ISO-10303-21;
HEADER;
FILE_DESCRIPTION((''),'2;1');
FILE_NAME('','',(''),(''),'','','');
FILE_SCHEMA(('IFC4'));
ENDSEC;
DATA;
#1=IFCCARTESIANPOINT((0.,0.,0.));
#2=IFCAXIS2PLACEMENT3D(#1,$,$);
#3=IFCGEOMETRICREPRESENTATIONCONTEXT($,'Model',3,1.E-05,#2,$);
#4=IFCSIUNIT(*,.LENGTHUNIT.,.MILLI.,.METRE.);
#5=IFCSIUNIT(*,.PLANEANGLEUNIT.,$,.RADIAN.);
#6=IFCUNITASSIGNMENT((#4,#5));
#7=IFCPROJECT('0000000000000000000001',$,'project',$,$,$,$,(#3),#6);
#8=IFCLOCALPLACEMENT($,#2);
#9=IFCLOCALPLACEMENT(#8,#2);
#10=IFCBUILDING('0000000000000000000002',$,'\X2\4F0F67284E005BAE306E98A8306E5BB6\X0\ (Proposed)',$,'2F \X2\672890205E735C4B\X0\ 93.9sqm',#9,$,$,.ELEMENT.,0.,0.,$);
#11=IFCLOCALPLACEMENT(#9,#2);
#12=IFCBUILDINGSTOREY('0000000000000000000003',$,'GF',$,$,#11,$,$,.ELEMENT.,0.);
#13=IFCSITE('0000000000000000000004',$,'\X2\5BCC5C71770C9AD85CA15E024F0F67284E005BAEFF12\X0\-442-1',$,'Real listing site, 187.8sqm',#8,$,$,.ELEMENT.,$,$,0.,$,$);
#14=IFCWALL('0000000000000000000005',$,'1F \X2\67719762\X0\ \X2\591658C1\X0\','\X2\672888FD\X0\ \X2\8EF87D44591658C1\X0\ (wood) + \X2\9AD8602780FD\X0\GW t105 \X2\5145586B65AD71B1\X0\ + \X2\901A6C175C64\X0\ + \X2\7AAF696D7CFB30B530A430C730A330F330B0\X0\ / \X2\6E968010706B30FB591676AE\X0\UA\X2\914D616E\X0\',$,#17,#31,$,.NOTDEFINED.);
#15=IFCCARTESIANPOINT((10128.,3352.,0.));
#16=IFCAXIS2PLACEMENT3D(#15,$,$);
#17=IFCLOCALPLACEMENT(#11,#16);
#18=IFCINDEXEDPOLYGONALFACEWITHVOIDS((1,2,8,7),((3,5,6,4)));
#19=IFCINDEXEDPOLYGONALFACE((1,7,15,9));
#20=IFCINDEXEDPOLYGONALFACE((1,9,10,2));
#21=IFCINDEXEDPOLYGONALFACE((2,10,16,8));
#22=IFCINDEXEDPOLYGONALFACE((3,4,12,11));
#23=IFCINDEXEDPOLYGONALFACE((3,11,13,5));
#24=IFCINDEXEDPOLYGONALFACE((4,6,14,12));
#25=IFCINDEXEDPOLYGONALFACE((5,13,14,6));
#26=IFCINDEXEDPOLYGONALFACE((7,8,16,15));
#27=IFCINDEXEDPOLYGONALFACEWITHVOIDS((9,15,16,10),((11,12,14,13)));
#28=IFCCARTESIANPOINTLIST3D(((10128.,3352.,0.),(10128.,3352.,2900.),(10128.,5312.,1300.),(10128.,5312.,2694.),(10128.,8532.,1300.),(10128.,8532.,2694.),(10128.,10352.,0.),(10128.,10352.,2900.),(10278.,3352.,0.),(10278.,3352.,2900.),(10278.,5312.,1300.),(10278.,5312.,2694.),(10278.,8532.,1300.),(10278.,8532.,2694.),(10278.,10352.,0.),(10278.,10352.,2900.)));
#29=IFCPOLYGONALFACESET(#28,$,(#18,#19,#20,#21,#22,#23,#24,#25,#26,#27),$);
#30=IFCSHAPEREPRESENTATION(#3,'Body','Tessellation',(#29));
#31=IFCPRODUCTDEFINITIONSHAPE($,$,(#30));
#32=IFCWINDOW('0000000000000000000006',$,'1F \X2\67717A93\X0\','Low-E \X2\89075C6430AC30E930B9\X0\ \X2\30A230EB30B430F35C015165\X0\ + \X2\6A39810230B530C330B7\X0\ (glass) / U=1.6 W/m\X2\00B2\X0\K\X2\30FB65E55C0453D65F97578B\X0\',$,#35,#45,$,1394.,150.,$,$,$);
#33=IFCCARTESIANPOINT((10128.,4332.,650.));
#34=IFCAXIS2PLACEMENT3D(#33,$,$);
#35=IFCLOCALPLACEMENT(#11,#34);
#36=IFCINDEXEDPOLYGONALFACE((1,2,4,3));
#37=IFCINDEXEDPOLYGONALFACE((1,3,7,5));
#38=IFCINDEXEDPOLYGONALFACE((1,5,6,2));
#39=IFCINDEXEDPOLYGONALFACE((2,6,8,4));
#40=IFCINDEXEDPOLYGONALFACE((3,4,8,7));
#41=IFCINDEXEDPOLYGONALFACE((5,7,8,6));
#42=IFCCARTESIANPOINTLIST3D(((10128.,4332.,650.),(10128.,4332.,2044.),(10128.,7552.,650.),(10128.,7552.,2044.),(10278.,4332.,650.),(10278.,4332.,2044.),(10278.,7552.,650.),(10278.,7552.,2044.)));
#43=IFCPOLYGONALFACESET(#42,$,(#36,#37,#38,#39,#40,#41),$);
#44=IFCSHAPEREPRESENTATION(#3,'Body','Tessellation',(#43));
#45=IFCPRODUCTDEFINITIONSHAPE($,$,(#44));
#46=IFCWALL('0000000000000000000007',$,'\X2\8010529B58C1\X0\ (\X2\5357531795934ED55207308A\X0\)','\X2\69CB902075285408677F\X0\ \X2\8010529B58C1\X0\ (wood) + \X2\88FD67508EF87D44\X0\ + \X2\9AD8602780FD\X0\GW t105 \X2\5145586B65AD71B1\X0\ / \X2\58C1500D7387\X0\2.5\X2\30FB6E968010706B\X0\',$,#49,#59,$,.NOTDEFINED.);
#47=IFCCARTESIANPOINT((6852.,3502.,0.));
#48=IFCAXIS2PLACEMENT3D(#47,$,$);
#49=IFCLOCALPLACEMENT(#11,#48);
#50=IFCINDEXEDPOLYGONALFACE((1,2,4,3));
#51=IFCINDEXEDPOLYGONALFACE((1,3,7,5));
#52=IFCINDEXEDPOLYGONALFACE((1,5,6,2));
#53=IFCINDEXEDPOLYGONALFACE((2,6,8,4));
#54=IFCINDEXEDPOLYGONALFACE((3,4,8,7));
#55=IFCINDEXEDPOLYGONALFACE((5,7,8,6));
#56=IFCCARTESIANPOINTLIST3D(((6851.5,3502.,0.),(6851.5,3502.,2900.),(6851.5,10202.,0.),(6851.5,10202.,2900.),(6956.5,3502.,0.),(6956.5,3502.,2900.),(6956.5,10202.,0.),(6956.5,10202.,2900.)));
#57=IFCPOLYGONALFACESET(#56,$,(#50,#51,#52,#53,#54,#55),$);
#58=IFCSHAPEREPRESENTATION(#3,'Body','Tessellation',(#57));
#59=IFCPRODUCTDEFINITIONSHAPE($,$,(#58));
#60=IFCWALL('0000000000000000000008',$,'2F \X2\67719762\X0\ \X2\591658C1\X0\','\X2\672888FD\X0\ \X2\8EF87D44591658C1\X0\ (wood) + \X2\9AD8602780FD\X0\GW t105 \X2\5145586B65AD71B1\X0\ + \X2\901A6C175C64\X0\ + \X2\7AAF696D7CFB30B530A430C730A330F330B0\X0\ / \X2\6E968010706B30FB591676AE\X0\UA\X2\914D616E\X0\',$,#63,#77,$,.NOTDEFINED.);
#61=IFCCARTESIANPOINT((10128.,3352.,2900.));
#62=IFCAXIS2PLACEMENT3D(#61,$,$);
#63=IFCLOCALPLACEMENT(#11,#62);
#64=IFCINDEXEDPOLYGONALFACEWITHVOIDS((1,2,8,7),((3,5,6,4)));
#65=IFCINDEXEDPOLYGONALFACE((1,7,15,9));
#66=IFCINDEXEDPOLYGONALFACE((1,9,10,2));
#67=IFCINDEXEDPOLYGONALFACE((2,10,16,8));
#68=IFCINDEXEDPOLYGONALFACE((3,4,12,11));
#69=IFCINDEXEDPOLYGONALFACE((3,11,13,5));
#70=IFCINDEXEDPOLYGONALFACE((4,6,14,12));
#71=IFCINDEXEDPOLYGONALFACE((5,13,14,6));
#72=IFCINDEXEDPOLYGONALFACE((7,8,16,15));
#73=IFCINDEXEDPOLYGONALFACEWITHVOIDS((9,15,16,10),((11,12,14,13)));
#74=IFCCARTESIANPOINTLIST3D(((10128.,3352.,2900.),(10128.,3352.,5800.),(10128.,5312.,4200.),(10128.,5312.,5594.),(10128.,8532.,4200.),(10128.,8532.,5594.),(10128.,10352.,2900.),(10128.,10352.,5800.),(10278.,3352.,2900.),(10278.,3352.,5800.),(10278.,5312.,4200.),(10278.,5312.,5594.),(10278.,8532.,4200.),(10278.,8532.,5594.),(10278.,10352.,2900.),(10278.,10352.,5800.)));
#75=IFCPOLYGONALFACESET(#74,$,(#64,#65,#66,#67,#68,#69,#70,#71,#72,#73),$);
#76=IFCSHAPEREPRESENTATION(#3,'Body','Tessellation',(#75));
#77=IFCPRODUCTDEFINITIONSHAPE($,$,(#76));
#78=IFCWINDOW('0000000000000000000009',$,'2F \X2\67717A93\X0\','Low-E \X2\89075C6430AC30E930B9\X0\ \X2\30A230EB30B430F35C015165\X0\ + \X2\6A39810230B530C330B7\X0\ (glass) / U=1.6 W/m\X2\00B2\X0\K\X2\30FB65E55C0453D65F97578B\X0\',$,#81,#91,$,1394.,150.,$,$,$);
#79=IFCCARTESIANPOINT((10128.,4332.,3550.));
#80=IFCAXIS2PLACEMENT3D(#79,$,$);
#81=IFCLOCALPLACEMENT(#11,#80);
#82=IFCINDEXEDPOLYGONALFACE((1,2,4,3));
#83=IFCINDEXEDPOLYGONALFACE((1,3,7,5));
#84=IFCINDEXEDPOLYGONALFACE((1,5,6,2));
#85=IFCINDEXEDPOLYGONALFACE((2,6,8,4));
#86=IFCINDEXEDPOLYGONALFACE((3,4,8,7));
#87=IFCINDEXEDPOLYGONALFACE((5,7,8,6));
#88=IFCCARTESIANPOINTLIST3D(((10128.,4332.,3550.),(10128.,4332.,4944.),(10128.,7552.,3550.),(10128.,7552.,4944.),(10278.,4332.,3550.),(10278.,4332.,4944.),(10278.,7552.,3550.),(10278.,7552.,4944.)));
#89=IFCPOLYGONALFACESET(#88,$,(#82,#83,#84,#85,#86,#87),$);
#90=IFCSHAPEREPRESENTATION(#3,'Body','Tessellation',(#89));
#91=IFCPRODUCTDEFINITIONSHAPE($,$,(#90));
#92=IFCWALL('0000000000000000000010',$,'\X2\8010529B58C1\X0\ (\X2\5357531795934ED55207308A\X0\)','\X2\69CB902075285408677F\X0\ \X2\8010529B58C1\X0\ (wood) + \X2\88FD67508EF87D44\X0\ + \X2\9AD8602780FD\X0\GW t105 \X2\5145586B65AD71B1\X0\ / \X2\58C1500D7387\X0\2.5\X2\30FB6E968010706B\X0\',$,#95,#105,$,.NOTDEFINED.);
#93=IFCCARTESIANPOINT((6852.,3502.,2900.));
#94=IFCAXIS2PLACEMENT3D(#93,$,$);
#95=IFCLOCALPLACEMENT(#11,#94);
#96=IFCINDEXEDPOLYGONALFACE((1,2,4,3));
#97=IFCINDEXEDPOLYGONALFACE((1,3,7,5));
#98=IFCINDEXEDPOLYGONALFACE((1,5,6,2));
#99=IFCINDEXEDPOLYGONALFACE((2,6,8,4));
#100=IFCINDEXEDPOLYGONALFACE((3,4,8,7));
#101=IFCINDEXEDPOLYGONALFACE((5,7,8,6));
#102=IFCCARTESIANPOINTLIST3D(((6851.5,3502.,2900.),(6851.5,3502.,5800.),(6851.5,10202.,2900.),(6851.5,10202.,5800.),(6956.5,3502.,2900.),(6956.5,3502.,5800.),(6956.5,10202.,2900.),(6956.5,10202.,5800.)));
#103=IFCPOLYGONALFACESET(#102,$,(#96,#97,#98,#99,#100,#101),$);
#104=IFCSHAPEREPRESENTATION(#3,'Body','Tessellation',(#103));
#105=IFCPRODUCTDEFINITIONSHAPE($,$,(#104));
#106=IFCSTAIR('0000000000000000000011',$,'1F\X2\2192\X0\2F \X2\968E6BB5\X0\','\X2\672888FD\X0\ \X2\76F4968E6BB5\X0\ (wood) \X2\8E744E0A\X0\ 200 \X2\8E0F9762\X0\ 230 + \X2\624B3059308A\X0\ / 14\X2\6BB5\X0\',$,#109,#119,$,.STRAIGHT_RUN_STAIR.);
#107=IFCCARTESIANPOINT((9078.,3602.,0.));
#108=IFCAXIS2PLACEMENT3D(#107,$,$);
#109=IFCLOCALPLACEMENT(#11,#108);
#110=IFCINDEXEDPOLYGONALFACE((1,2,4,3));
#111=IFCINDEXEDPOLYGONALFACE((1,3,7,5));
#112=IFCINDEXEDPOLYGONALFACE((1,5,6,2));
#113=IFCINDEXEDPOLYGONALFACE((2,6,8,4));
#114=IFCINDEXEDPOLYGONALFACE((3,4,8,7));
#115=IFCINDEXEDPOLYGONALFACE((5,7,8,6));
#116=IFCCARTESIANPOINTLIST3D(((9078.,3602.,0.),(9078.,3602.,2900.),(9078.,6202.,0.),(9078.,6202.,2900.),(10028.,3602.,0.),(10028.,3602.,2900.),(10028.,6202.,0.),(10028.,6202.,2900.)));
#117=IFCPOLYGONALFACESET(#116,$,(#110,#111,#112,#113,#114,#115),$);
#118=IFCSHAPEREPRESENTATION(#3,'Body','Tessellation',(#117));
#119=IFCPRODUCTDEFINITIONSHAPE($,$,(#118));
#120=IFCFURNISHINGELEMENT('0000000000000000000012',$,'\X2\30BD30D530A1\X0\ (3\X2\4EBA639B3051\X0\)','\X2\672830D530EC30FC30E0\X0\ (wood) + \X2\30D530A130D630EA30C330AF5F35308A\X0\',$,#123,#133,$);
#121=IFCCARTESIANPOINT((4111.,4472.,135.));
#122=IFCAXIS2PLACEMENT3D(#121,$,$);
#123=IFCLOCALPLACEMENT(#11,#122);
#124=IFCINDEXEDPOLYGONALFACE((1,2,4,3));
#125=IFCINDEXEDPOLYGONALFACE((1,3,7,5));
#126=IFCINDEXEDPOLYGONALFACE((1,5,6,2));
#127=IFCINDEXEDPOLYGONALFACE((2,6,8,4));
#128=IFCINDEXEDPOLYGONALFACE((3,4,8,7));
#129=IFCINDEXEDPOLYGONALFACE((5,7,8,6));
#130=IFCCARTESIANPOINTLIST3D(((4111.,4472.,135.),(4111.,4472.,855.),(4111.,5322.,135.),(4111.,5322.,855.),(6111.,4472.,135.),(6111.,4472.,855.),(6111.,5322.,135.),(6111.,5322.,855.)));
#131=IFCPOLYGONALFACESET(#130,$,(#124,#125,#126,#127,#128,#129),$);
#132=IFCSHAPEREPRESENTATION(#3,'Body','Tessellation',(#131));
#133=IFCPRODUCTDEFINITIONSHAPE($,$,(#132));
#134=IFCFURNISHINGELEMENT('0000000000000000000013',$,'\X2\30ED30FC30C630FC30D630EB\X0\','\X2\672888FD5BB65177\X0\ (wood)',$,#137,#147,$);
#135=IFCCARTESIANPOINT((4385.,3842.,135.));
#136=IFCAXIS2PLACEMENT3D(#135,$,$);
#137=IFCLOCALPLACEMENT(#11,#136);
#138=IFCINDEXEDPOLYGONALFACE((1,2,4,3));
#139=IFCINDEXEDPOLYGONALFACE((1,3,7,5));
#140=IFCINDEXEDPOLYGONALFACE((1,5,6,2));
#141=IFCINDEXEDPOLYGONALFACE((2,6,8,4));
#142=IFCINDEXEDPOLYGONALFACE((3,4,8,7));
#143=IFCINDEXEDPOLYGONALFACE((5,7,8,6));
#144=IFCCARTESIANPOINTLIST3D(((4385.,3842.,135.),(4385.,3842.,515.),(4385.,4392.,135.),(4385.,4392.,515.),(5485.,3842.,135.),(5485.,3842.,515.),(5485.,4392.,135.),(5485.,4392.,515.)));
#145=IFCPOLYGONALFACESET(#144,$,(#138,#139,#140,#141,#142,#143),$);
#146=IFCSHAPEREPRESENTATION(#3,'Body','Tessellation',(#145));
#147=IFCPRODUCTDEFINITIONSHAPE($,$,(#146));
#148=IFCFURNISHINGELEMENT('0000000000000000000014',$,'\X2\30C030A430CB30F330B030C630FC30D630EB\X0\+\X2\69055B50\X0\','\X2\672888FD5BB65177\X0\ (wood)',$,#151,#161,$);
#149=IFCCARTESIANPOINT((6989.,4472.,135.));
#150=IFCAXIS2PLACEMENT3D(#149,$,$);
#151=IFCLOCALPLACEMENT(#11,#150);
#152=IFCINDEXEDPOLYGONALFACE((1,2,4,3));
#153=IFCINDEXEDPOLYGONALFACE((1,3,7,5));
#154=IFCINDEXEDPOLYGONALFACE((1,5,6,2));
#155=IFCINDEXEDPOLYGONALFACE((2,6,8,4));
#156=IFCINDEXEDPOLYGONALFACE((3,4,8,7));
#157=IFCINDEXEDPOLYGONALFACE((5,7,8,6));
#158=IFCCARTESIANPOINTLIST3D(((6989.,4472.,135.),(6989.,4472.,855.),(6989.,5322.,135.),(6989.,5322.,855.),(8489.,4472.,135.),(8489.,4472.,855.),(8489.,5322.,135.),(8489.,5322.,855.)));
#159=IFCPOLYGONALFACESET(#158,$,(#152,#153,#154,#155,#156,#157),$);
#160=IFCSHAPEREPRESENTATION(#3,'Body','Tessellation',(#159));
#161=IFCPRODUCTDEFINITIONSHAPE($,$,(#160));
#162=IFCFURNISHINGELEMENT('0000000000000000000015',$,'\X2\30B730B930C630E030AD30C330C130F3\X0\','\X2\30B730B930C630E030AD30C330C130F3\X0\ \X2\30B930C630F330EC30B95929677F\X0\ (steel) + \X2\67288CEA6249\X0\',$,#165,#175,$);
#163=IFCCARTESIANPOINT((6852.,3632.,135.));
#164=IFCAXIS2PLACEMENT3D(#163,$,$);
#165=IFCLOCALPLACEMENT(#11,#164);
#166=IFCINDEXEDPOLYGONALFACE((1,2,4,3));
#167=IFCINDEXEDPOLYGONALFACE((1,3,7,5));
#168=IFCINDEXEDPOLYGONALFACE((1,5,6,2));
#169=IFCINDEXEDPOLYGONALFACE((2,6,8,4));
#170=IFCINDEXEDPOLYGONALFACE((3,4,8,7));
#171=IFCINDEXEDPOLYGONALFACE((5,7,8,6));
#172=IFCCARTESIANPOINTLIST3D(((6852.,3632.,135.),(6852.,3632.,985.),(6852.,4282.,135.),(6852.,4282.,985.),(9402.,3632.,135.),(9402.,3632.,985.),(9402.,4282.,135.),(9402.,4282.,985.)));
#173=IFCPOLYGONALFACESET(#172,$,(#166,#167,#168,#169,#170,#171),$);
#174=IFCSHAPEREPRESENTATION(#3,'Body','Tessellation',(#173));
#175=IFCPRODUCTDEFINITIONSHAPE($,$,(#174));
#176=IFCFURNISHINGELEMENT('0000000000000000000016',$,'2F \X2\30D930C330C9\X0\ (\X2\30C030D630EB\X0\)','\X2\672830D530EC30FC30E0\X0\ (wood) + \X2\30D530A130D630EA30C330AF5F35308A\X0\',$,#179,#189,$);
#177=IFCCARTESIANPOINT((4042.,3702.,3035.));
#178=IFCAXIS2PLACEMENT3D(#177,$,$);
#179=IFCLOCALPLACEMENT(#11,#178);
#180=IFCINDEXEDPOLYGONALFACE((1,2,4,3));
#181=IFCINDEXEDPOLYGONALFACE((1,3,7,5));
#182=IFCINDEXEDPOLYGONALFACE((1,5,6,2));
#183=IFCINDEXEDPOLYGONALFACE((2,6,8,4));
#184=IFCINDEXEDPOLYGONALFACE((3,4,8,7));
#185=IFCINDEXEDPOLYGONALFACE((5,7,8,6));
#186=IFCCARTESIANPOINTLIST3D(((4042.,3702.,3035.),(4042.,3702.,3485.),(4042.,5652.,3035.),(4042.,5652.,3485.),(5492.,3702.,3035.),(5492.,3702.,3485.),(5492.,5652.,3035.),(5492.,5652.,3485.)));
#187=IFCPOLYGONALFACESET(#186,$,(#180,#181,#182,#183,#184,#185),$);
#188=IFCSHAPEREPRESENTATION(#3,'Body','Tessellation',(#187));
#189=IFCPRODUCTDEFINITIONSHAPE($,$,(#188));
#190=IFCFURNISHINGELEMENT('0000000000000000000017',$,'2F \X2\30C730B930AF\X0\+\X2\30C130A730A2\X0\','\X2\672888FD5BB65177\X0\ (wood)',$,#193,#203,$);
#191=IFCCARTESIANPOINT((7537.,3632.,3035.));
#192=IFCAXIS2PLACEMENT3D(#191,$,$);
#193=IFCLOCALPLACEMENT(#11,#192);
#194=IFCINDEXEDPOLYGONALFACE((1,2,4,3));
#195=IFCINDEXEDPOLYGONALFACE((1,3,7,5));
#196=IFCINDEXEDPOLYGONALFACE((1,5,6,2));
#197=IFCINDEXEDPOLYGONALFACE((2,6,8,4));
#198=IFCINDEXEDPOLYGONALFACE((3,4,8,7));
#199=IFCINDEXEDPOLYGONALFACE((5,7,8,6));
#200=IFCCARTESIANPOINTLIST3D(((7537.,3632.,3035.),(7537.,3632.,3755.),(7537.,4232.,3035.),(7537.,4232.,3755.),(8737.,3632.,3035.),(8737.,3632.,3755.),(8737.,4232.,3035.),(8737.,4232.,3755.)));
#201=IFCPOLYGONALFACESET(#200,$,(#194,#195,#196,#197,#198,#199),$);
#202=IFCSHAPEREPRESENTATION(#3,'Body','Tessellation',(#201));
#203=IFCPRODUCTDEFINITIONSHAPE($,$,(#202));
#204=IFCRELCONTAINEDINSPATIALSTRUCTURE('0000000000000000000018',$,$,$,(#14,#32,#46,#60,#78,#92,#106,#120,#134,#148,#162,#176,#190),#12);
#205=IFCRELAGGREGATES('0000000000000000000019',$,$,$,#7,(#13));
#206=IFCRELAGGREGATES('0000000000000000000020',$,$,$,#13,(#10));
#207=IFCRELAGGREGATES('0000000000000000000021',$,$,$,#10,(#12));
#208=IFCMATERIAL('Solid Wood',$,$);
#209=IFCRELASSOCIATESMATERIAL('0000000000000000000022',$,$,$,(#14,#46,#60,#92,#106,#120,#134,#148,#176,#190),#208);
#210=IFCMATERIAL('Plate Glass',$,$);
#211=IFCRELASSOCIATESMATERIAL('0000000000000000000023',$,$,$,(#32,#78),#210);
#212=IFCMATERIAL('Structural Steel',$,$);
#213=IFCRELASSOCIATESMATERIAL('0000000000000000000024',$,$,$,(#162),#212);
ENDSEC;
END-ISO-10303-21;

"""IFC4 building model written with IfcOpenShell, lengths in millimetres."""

from ifc_helpers import new_model, si_unit, frame, frame_2d, origin, place, context, project, spatial, rectangle, extrude, material, element, fill, save


model = new_model("IFC4")

# Units and contexts
model_context = context("Model", 3, precision=1e-05, world=origin())
ifc_project = project(units=[si_unit("LENGTHUNIT", "METRE", prefix="MILLI"), si_unit("PLANEANGLEUNIT", "RADIAN")], contexts=[model_context])

# Site, building, storey
site_placement = place(None, origin())
site = spatial("IfcSite", under=ifc_project, at=site_placement, Name="富山県高岡市伏木一宮２-442-1", ObjectType="Real listing site, 187.8sqm", CompositionType="ELEMENT", RefElevation=0.0)
building_placement = place(site_placement, origin())
building = spatial("IfcBuilding", under=site, at=building_placement, Name="伏木一宮の風の家 (Proposed)", ObjectType="2F 木造平屋 93.9sqm", CompositionType="ELEMENT", ElevationOfRefHeight=0.0, ElevationOfTerrain=0.0)
storey_placement = place(building_placement, origin())
storey = spatial("IfcBuildingStorey", under=building, at=storey_placement, Name="GF", CompositionType="ELEMENT", Elevation=0.0)

# Wall, opening, window
ifc_material_1 = material(Name="Solid Wood")
wall_1_placement = place(storey_placement, frame((10128.0, 3352.0, 0.0)))
wall_1 = element("IfcWall", 1, at=wall_1_placement, inside=storey, material=ifc_material_1, Name="1F 東面 外壁", Description="木製 軸組外壁 (wood) + 高性能GW t105 充填断熱 + 通気層 + 窯業系サイディング / 準耐火・外皮UA配慮", PredefinedType="NOTDEFINED", context=model_context, shape_type="SweptSolid", body=[
    extrude(rectangle(XDim=150.0, YDim=7000.0, at=frame_2d((75.0, 3500.0))), frame((10128.0, 3352.0, 0.0)), (0.0, 0.0, 1.0), 2900.0),
])
opening_1_placement = place(storey_placement, frame((10128.0, 4332.0, 650.0)))
opening_1 = element("IfcOpeningElement", 2, at=opening_1_placement, cuts=wall_1, PredefinedType="NOTDEFINED", context=model_context, shape_type="SweptSolid", body=[
    extrude(rectangle(XDim=150.0, YDim=3220.0, at=frame_2d((75.0, 1610.0))), frame((10128.0, 4332.0, 650.0)), (0.0, 0.0, 1.0), 1394.0),
])
ifc_material_2 = material(Name="Plate Glass")
window_1_placement = place(storey_placement, frame((10128.0, 4332.0, 650.0)))
window_1 = element("IfcWindow", 3, at=window_1_placement, inside=storey, material=ifc_material_2, Name="1F 東窓", Description="Low-E 複層ガラス アルゴン封入 + 樹脂サッシ (glass) / U=1.6 W/m²K・日射取得型", OverallHeight=1394.0, OverallWidth=150.0, context=model_context, shape_type="SweptSolid", body=[
    extrude(rectangle(XDim=150.0, YDim=3220.0, at=frame_2d((75.0, 1610.0))), frame((10128.0, 4332.0, 650.0)), (0.0, 0.0, 1.0), 1394.0),
])
fill(opening_1, window_1)

# Wall
wall_2_placement = place(storey_placement, frame((6852.0, 3502.0, 0.0)))
element("IfcWall", 4, at=wall_2_placement, inside=storey, material=ifc_material_1, Name="耐力壁 (南北間仕切り)", Description="構造用合板 耐力壁 (wood) + 製材軸組 + 高性能GW t105 充填断熱 / 壁倍率2.5・準耐火", PredefinedType="NOTDEFINED", context=model_context, shape_type="SweptSolid", body=[
    extrude(rectangle(XDim=105.0, YDim=6700.0, at=frame_2d((52.0, 3350.0))), frame((6852.0, 3502.0, 0.0)), (0.0, 0.0, 1.0), 2900.0),
])

# Wall, opening, window
wall_3_placement = place(storey_placement, frame((10128.0, 3352.0, 2900.0)))
wall_3 = element("IfcWall", 5, at=wall_3_placement, inside=storey, material=ifc_material_1, Name="2F 東面 外壁", Description="木製 軸組外壁 (wood) + 高性能GW t105 充填断熱 + 通気層 + 窯業系サイディング / 準耐火・外皮UA配慮", PredefinedType="NOTDEFINED", context=model_context, shape_type="SweptSolid", body=[
    extrude(rectangle(XDim=150.0, YDim=7000.0, at=frame_2d((75.0, 3500.0))), frame((10128.0, 3352.0, 2900.0)), (0.0, 0.0, 1.0), 2900.0),
])
opening_2_placement = place(storey_placement, frame((10128.0, 4332.0, 3550.0)))
opening_2 = element("IfcOpeningElement", 6, at=opening_2_placement, cuts=wall_3, PredefinedType="NOTDEFINED", context=model_context, shape_type="SweptSolid", body=[
    extrude(rectangle(XDim=150.0, YDim=3220.0, at=frame_2d((75.0, 1610.0))), frame((10128.0, 4332.0, 3550.0)), (0.0, 0.0, 1.0), 1394.0),
])
window_2_placement = place(storey_placement, frame((10128.0, 4332.0, 3550.0)))
window_2 = element("IfcWindow", 7, at=window_2_placement, inside=storey, material=ifc_material_2, Name="2F 東窓", Description="Low-E 複層ガラス アルゴン封入 + 樹脂サッシ (glass) / U=1.6 W/m²K・日射取得型", OverallHeight=1394.0, OverallWidth=150.0, context=model_context, shape_type="SweptSolid", body=[
    extrude(rectangle(XDim=150.0, YDim=3220.0, at=frame_2d((75.0, 1610.0))), frame((10128.0, 4332.0, 3550.0)), (0.0, 0.0, 1.0), 1394.0),
])
fill(opening_2, window_2)

# Wall
wall_4_placement = place(storey_placement, frame((6852.0, 3502.0, 2900.0)))
element("IfcWall", 8, at=wall_4_placement, inside=storey, material=ifc_material_1, Name="耐力壁 (南北間仕切り)", Description="構造用合板 耐力壁 (wood) + 製材軸組 + 高性能GW t105 充填断熱 / 壁倍率2.5・準耐火", PredefinedType="NOTDEFINED", context=model_context, shape_type="SweptSolid", body=[
    extrude(rectangle(XDim=105.0, YDim=6700.0, at=frame_2d((52.0, 3350.0))), frame((6852.0, 3502.0, 2900.0)), (0.0, 0.0, 1.0), 2900.0),
])

# Stair
stair_placement = place(storey_placement, frame((9078.0, 3602.0, 0.0)))
element("IfcStair", 9, at=stair_placement, inside=storey, material=ifc_material_1, Name="1F→2F 階段", Description="木製 直階段 (wood) 蹴上 200 踏面 230 + 手すり / 14段", PredefinedType="STRAIGHT_RUN_STAIR", context=model_context, shape_type="SweptSolid", body=[
    extrude(rectangle(XDim=950.0, YDim=2600.0, at=frame_2d((475.0, 1300.0))), frame((9078.0, 3602.0, 0.0)), (0.0, 0.0, 1.0), 2900.0),
])

# Furnishing elements
furnishing_1_placement = place(storey_placement, frame((4111.0, 4472.0, 135.0)))
element("IfcFurnishingElement", 10, at=furnishing_1_placement, inside=storey, material=ifc_material_1, Name="ソファ (3人掛け)", Description="木フレーム (wood) + ファブリック張り", context=model_context, shape_type="SweptSolid", body=[
    extrude(rectangle(XDim=2000.0, YDim=850.0, at=frame_2d((1000.0, 425.0))), frame((4111.0, 4472.0, 135.0)), (0.0, 0.0, 1.0), 720.0),
])
furnishing_2_placement = place(storey_placement, frame((4385.0, 3842.0, 135.0)))
element("IfcFurnishingElement", 11, at=furnishing_2_placement, inside=storey, material=ifc_material_1, Name="ローテーブル", Description="木製家具 (wood)", context=model_context, shape_type="SweptSolid", body=[
    extrude(rectangle(XDim=1100.0, YDim=550.0, at=frame_2d((550.0, 275.0))), frame((4385.0, 3842.0, 135.0)), (0.0, 0.0, 1.0), 380.0),
])
furnishing_3_placement = place(storey_placement, frame((6989.0, 4472.0, 135.0)))
element("IfcFurnishingElement", 12, at=furnishing_3_placement, inside=storey, material=ifc_material_1, Name="ダイニングテーブル+椅子", Description="木製家具 (wood)", context=model_context, shape_type="SweptSolid", body=[
    extrude(rectangle(XDim=1500.0, YDim=850.0, at=frame_2d((750.0, 425.0))), frame((6989.0, 4472.0, 135.0)), (0.0, 0.0, 1.0), 720.0),
])
ifc_material_3 = material(Name="Structural Steel")
furnishing_4_placement = place(storey_placement, frame((6852.0, 3632.0, 135.0)))
element("IfcFurnishingElement", 13, at=furnishing_4_placement, inside=storey, material=ifc_material_3, Name="システムキッチン", Description="システムキッチン ステンレス天板 (steel) + 木質扉", context=model_context, shape_type="SweptSolid", body=[
    extrude(rectangle(XDim=2550.0, YDim=650.0, at=frame_2d((1275.0, 325.0))), frame((6852.0, 3632.0, 135.0)), (0.0, 0.0, 1.0), 850.0),
])
furnishing_5_placement = place(storey_placement, frame((4042.0, 3702.0, 3035.0)))
element("IfcFurnishingElement", 14, at=furnishing_5_placement, inside=storey, material=ifc_material_1, Name="2F ベッド (ダブル)", Description="木フレーム (wood) + ファブリック張り", context=model_context, shape_type="SweptSolid", body=[
    extrude(rectangle(XDim=1450.0, YDim=1950.0, at=frame_2d((725.0, 975.0))), frame((4042.0, 3702.0, 3035.0)), (0.0, 0.0, 1.0), 450.0),
])
furnishing_6_placement = place(storey_placement, frame((7537.0, 3632.0, 3035.0)))
element("IfcFurnishingElement", 15, at=furnishing_6_placement, inside=storey, material=ifc_material_1, Name="2F デスク+チェア", Description="木製家具 (wood)", context=model_context, shape_type="SweptSolid", body=[
    extrude(rectangle(XDim=1200.0, YDim=600.0, at=frame_2d((600.0, 300.0))), frame((7537.0, 3632.0, 3035.0)), (0.0, 0.0, 1.0), 720.0),
])

save(model, "model.ifc")
